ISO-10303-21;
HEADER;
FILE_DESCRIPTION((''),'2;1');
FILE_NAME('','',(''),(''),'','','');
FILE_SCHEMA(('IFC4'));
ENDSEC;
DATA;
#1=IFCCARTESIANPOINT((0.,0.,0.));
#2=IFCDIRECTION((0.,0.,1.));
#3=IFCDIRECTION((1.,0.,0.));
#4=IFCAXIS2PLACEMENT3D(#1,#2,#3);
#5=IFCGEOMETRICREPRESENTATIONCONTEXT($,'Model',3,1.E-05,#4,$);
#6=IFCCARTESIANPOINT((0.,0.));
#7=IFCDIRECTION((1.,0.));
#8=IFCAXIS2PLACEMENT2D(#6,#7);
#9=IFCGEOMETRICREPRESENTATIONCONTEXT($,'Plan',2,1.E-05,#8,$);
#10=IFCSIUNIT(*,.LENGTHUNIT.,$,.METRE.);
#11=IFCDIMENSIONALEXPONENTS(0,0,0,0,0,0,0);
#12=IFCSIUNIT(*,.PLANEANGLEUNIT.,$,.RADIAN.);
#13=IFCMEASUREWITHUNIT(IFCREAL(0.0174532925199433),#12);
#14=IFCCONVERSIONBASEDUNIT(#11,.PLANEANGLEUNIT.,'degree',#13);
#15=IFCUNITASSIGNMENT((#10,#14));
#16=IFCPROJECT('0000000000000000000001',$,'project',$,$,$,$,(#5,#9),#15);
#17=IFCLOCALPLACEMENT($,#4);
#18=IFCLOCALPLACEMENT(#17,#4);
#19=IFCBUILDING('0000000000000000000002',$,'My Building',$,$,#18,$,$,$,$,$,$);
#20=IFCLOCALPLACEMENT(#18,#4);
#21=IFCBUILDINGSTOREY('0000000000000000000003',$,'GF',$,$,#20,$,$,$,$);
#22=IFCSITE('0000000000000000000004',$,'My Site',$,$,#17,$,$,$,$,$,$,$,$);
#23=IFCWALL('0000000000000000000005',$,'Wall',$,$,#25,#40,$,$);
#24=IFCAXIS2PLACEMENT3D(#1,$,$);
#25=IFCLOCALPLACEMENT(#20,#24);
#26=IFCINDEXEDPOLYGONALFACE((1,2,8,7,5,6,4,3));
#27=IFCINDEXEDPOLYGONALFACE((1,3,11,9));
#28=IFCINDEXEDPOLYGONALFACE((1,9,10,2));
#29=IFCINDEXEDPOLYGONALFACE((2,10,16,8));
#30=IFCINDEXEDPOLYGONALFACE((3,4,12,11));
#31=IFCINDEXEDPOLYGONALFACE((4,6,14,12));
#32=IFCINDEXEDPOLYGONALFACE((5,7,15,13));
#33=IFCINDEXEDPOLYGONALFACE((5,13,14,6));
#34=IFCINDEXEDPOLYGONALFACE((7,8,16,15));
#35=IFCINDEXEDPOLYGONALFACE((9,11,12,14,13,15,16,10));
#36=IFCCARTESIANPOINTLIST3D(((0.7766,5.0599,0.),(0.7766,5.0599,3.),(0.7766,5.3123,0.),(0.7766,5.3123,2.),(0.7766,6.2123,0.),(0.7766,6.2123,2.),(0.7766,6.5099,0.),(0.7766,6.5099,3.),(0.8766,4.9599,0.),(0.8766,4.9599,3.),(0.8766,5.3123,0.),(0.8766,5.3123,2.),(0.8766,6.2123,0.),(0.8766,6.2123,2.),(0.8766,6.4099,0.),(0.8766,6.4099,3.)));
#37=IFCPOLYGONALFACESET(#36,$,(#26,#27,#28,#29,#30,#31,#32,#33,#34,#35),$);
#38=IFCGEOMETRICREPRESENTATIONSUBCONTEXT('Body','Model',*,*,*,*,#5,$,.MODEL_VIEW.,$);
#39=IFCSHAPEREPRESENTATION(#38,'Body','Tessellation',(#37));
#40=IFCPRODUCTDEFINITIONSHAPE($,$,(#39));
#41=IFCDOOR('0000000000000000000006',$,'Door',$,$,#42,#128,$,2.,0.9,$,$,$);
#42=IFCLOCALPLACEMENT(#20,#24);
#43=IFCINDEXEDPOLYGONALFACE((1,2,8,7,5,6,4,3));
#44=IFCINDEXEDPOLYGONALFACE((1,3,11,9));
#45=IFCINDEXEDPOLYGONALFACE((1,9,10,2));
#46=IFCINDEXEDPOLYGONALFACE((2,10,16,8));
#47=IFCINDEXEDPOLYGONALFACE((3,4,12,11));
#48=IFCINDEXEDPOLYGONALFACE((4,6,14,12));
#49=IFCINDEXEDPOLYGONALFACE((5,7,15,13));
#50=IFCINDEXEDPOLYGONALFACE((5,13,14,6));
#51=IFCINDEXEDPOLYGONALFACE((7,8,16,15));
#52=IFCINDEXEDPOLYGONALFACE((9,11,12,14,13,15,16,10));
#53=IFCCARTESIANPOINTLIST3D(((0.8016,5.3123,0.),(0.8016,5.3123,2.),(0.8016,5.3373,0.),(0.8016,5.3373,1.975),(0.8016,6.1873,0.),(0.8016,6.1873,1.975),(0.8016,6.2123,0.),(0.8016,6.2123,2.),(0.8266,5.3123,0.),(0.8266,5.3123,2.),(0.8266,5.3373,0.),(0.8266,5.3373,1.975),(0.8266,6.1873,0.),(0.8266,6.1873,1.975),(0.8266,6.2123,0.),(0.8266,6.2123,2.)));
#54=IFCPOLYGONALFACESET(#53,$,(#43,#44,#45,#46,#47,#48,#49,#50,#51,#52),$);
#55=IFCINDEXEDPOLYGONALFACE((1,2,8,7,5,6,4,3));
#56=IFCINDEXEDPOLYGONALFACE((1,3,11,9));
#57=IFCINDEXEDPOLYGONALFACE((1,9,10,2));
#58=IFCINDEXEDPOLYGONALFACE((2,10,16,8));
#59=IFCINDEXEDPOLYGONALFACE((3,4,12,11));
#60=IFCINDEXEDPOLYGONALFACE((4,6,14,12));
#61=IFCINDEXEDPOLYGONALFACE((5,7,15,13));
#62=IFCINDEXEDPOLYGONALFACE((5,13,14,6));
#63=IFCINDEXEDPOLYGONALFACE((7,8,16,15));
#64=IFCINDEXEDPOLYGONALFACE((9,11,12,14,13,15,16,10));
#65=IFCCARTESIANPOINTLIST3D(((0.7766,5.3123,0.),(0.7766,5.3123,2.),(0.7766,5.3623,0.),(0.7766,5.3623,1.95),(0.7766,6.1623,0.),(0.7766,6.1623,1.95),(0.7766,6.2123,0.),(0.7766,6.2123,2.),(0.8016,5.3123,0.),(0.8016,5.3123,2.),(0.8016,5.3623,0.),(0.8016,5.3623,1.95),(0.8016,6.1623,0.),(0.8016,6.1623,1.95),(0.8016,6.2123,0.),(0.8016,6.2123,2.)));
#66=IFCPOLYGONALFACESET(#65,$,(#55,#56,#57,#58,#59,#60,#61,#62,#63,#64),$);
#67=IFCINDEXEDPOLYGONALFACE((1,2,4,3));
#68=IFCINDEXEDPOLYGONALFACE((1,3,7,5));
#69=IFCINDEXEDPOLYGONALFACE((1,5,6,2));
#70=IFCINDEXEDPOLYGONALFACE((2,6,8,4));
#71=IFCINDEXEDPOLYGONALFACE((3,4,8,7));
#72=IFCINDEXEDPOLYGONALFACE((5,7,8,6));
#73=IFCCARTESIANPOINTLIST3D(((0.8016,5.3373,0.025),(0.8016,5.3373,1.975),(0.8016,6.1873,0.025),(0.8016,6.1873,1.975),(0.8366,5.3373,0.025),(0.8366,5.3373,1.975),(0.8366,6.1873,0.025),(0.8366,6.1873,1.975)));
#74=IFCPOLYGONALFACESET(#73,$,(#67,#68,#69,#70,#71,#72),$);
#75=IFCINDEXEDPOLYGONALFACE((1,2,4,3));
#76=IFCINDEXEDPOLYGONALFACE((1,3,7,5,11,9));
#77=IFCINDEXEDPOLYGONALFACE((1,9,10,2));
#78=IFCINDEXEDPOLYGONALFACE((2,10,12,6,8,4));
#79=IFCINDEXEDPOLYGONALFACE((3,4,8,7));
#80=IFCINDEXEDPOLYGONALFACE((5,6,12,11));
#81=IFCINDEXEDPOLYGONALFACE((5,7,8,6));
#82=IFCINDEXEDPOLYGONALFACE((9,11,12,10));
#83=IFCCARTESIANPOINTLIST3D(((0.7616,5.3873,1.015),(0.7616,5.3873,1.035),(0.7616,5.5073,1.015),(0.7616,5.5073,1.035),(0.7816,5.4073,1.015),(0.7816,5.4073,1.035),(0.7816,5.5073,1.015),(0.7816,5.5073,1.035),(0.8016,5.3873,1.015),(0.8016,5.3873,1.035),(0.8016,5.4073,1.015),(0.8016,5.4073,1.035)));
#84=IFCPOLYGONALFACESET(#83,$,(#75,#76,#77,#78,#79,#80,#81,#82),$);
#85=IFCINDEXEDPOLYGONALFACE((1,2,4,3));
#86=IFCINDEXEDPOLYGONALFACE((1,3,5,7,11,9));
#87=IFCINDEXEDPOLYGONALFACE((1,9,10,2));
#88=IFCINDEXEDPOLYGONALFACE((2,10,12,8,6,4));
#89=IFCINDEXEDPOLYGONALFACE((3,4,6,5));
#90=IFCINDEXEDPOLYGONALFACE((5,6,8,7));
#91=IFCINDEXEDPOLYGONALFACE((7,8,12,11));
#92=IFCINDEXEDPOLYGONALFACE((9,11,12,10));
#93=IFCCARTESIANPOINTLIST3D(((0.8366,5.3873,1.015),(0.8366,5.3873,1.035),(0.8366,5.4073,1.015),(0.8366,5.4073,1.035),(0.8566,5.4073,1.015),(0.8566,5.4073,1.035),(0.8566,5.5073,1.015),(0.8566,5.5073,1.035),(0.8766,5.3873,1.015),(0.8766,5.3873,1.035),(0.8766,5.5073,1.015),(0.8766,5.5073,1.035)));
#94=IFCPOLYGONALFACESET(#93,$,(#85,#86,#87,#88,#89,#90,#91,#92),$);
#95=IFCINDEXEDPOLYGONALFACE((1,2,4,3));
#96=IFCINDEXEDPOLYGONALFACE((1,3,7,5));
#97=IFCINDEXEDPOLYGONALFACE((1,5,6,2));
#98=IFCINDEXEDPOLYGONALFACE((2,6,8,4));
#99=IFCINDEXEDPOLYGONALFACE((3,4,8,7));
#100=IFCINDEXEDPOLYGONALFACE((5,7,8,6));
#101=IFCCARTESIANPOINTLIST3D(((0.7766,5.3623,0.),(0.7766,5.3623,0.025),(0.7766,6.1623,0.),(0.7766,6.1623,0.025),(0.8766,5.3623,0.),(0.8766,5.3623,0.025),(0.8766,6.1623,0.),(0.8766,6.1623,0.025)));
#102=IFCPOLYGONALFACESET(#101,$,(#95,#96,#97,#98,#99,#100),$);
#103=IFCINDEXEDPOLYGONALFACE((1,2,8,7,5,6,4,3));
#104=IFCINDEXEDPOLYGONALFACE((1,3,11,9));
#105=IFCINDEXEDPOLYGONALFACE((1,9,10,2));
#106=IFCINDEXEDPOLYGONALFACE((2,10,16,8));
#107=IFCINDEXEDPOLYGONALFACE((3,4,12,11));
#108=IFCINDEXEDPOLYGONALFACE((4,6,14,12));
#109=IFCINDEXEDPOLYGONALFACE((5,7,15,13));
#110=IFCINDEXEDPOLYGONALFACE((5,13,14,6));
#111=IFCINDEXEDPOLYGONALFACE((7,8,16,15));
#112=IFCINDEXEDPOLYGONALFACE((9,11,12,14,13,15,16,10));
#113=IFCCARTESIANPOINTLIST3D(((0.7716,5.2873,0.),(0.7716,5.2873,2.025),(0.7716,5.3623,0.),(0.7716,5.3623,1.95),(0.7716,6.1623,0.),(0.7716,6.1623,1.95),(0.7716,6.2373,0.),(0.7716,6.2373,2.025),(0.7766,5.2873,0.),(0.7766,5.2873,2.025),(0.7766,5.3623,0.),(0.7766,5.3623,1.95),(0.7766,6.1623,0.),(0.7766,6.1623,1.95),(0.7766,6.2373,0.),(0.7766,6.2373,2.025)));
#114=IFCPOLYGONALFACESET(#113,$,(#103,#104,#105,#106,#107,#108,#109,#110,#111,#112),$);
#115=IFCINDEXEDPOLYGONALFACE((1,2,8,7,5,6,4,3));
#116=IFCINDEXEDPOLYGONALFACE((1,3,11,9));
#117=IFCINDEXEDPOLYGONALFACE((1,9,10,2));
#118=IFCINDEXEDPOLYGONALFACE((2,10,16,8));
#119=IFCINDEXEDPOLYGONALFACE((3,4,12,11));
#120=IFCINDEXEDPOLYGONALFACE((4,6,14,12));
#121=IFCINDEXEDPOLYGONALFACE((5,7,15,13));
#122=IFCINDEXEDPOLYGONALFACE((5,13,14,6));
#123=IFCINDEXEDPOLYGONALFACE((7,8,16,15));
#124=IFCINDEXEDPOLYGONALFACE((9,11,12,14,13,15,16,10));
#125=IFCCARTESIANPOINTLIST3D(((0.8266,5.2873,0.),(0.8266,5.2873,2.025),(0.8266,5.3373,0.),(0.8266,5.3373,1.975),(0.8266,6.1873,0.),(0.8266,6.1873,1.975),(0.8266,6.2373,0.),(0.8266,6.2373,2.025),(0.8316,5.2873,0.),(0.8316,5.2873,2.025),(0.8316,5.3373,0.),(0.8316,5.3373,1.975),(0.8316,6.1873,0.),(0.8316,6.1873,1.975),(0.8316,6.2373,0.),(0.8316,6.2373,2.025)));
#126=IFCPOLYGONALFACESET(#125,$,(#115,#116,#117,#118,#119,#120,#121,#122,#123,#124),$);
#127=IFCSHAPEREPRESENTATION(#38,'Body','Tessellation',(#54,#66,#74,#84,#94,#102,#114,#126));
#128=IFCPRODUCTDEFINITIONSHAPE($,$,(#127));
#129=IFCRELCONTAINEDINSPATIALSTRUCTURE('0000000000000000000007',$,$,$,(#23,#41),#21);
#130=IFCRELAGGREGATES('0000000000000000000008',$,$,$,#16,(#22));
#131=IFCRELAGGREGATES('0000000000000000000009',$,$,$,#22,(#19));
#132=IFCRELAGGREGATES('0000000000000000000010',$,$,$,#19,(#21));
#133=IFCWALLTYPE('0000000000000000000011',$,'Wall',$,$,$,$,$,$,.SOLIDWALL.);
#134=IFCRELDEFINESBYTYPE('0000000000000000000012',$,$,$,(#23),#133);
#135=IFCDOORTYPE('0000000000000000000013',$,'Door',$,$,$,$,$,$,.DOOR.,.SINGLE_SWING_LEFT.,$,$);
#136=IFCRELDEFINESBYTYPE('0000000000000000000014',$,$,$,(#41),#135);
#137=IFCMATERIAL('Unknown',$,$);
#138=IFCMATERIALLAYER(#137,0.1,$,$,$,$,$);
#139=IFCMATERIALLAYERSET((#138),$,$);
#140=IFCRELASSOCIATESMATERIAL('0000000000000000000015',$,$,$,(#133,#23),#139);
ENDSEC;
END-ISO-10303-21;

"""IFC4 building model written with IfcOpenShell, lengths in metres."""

from ifc_helpers import new_model, entity, si_unit, converted_unit, frame, origin_with_axes, origin_2d_with_axis, place, context, subcontext, project, spatial, line, indexed_curve, outline, extrude, shape, source, transform, mapped, material, layer, layer_set, layer_usage, type_object, type_shapes, element, fill, save


model = new_model("IFC4")

# Units and contexts
model_context = context("Model", 3, precision=1e-05, world=origin_with_axes())
plan_context = context("Plan", 2, precision=1e-05, world=origin_2d_with_axis())
body_context_1 = subcontext(model_context, "Body", "Model", "MODEL_VIEW")
body_context_2 = subcontext(plan_context, "Body", "Plan", "PLAN_VIEW")
ifc_project = project(units=[si_unit("LENGTHUNIT", "METRE"), converted_unit("PLANEANGLEUNIT", "degree", entity("IfcReal", 0.0174532925199433), si_unit("PLANEANGLEUNIT", "RADIAN"), dimensions=[0, 0, 0, 0, 0, 0, 0])], contexts=[model_context, plan_context])

# Site, building, storey
site_placement = place(None, origin_with_axes())
site = spatial("IfcSite", under=ifc_project, at=site_placement, Name="My Site")
building_placement = place(site_placement, origin_with_axes())
building = spatial("IfcBuilding", under=site, at=building_placement, Name="My Building")
storey_placement = place(building_placement, origin_with_axes())
storey = spatial("IfcBuildingStorey", under=building, at=storey_placement, Name="GF")

# Shared definitions
ifc_material = material(Name="Unknown")

# Shared definitions
ifc_layer = layer(ifc_material, 0.1)
ifc_layer_set = layer_set([ifc_layer])
wall_type = type_object("IfcWallType", Name="Wall", PredefinedType="SOLIDWALL", material=ifc_layer_set)

# Wall, opening, door
ifc_layer_usage_1 = layer_usage(ifc_layer_set, "AXIS2", "POSITIVE", 0.0)
wall_1_placement = place(storey_placement, frame((0.7766, 6.5099, 0.0), z_axis=(0.0, 0.0, 1.0), x_axis=(0.0, -1.0, 0.0)))
wall_1 = element("IfcWall", 1, at=wall_1_placement, inside=storey, type_object=wall_type, material=ifc_layer_usage_1, Name="Wall", context=body_context_1, shape_type="SweptSolid", body=[
    extrude(outline(indexed_curve([(0.0, 0.0), (0.1, 0.1), (1.55, 0.1), (1.45, 0.0)], segments=[line(1, 2, 3, 4, 1)])), origin_with_axes(), (0.0, 0.0, 1.0), 3.0),
])
shared_shape_1 = source(origin_with_axes(), body_context_1, "Body", "SweptSolid", [
    extrude(outline(indexed_curve([(0.0, 0.0), (0.9, 0.0), (0.9, 2.0), (0.0, 2.0)], segments=[line(1, 2, 3, 4, 1)])), frame((0.0, -0.6, 0.0), z_axis=(0.0, -1.0, 0.0), x_axis=(1.0, 0.0, 0.0)), (0.0, 0.0, -1.0), 1.2),
])
opening_1_placement = place(wall_1_placement, frame((0.2976, 0.0, 0.0), z_axis=(0.0, 0.0, 1.0), x_axis=(1.0, 0.0, 0.0)))
opening_1 = element("IfcOpeningElement", 2, at=opening_1_placement, cuts=wall_1, PredefinedType="OPENING", context=body_context_1, shape_type="MappedRepresentation", body=[
    mapped(shared_shape_1, transform((0.0, 0.0, 0.0), x_axis=(1.0, 0.0, 0.0), y_axis=(0.0, 1.0, 0.0), z_axis=(0.0, 0.0, 1.0), scale=1.0)),
])
door_type = type_object("IfcDoorType", Name="Door", OperationType="SINGLE_SWING_LEFT", PredefinedType="DOOR")
shared_shape_2 = source(origin_with_axes(), body_context_1, "Body", "SweptSolid", [
    extrude(outline(indexed_curve([(0.0, 0.0), (0.0, 2.0), (0.9, 2.0), (0.9, 0.0), (0.875, 0.0), (0.875, 1.975), (0.025, 1.975), (0.025, 0.0)], segments=[line(1, 2, 3, 4, 5, 6, 7, 8, 1)])), frame((0.0, 0.025, 0.0), z_axis=(0.0, -1.0, 0.0), x_axis=(1.0, 0.0, 0.0)), (0.0, 0.0, -1.0), 0.025),
    extrude(outline(indexed_curve([(0.0, 0.0), (0.0, 2.0), (0.9, 2.0), (0.9, 0.0), (0.85, 0.0), (0.85, 1.95), (0.05, 1.95), (0.05, 0.0)], segments=[line(1, 2, 3, 4, 5, 6, 7, 8, 1)])), frame((0.0, 0.0, 0.0), z_axis=(0.0, -1.0, 0.0), x_axis=(1.0, 0.0, 0.0)), (0.0, 0.0, -1.0), 0.025),
    extrude(outline(indexed_curve([(0.0, 0.0), (0.85, 0.0), (0.85, 0.035), (0.0, 0.035)], segments=[line(1, 2, 3, 4, 1)])), frame((0.025, 0.025, 0.025), z_axis=(0.0, 0.0, 1.0), x_axis=(1.0, 0.0, 0.0)), (0.0, 0.0, 1.0), 1.95),
    extrude(outline(indexed_curve([(0.0, 0.0), (0.0, -0.04), (-0.12, -0.04), (-0.12, -0.02), (-0.02, -0.02), (-0.02, 0.0)], segments=[line(1, 2, 3, 4, 5, 6, 1)])), frame((0.825, 0.025, 1.015), z_axis=(0.0, 0.0, 1.0), x_axis=(1.0, 0.0, 0.0)), (0.0, 0.0, 1.0), 0.02),
    extrude(outline(indexed_curve([(0.0, 0.0), (0.0, 0.04), (-0.12, 0.04), (-0.12, 0.02), (-0.02, 0.02), (-0.02, 0.0)], segments=[line(1, 2, 3, 4, 5, 6, 1)])), frame((0.825, 0.06, 1.015), z_axis=(0.0, 0.0, 1.0), x_axis=(1.0, 0.0, 0.0)), (0.0, 0.0, 1.0), 0.02),
    extrude(outline(indexed_curve([(0.0, 0.0), (0.8, 0.0), (0.8, 0.1), (0.0, 0.1)], segments=[line(1, 2, 3, 4, 1)])), frame((0.05, 0.0, 0.0), z_axis=(0.0, 0.0, 1.0), x_axis=(1.0, 0.0, 0.0)), (0.0, 0.0, 1.0), 0.025),
    extrude(outline(indexed_curve([(0.0, 0.0), (0.0, 2.025), (0.95, 2.025), (0.95, 0.0), (0.875, 0.0), (0.875, 1.95), (0.075, 1.95), (0.075, 0.0)], segments=[line(1, 2, 3, 4, 5, 6, 7, 8, 1)])), frame((-0.025, -0.005, 0.0), z_axis=(0.0, -1.0, 0.0), x_axis=(1.0, 0.0, 0.0)), (0.0, 0.0, -1.0), 0.005),
    extrude(outline(indexed_curve([(0.0, 0.0), (0.0, 2.025), (0.95, 2.025), (0.95, 0.0), (0.9, 0.0), (0.9, 1.975), (0.05, 1.975), (0.05, 0.0)], segments=[line(1, 2, 3, 4, 5, 6, 7, 8, 1)])), frame((-0.025, 0.05, 0.0), z_axis=(0.0, -1.0, 0.0), x_axis=(1.0, 0.0, 0.0)), (0.0, 0.0, -1.0), 0.005),
])
shared_shape_3 = source(origin_with_axes(), body_context_2, "Body", "Curve2D", [
    entity("IfcIndexedPolyCurve", entity("IfcCartesianPointList2D", [[0.0, 0.0], [0.0, 0.05], [0.025, 0.05], [0.025, 0.025], [0.05, 0.025], [0.05, 0.0]]), [entity("IfcLineIndex", [1, 2, 3, 4, 5, 6, 1])]),
    entity("IfcIndexedPolyCurve", entity("IfcCartesianPointList2D", [[0.9, 0.0], [0.9, 0.05], [0.875, 0.05], [0.875, 0.025], [0.85, 0.025], [0.85, 0.0]]), [entity("IfcLineIndex", [1, 2, 3, 4, 5, 6, 1])]),
    entity("IfcTrimmedCurve", entity("IfcEllipse", entity("IfcAxis2Placement2D", entity("IfcCartesianPoint", [0.06, 0.05]), entity("IfcDirection", [1.0, 0.0])), 0.815, 0.85), [entity("IfcCartesianPoint", [0.875, 0.05])], [entity("IfcCartesianPoint", [0.06, 0.9])], True, "CARTESIAN"),
    entity("IfcIndexedPolyCurve", entity("IfcCartesianPointList2D", [[0.025, 0.05], [0.06, 0.05], [0.06, 0.9], [0.025, 0.9]]), [entity("IfcLineIndex", [1, 2, 3, 4, 1])]),
])
type_shapes(door_type, [shared_shape_2, shared_shape_3])
door_1_placement = place(opening_1_placement, frame((0.0, 0.0, 0.0), z_axis=(0.0, 0.0, 1.0), x_axis=(1.0, 0.0, 0.0)))
door_1 = element("IfcDoor", 3, at=door_1_placement, inside=storey, type_object=door_type, Name="Door", OverallHeight=2.0, OverallWidth=0.9, shapes=[
    shape(body_context_1, "Body", "MappedRepresentation", [mapped(shared_shape_2, transform((0.0, 0.0, 0.0), x_axis=(1.0, 0.0, 0.0), y_axis=(0.0, 1.0, 0.0), z_axis=(0.0, 0.0, 1.0), scale=1.0))]),
    shape(body_context_2, "Body", "MappedRepresentation", [mapped(shared_shape_3, transform((0.0, 0.0, 0.0), x_axis=(1.0, 0.0, 0.0), y_axis=(0.0, 1.0, 0.0), z_axis=(0.0, 0.0, 1.0), scale=1.0))]),
])
fill(opening_1, door_1)

save(model, "model.ifc")
